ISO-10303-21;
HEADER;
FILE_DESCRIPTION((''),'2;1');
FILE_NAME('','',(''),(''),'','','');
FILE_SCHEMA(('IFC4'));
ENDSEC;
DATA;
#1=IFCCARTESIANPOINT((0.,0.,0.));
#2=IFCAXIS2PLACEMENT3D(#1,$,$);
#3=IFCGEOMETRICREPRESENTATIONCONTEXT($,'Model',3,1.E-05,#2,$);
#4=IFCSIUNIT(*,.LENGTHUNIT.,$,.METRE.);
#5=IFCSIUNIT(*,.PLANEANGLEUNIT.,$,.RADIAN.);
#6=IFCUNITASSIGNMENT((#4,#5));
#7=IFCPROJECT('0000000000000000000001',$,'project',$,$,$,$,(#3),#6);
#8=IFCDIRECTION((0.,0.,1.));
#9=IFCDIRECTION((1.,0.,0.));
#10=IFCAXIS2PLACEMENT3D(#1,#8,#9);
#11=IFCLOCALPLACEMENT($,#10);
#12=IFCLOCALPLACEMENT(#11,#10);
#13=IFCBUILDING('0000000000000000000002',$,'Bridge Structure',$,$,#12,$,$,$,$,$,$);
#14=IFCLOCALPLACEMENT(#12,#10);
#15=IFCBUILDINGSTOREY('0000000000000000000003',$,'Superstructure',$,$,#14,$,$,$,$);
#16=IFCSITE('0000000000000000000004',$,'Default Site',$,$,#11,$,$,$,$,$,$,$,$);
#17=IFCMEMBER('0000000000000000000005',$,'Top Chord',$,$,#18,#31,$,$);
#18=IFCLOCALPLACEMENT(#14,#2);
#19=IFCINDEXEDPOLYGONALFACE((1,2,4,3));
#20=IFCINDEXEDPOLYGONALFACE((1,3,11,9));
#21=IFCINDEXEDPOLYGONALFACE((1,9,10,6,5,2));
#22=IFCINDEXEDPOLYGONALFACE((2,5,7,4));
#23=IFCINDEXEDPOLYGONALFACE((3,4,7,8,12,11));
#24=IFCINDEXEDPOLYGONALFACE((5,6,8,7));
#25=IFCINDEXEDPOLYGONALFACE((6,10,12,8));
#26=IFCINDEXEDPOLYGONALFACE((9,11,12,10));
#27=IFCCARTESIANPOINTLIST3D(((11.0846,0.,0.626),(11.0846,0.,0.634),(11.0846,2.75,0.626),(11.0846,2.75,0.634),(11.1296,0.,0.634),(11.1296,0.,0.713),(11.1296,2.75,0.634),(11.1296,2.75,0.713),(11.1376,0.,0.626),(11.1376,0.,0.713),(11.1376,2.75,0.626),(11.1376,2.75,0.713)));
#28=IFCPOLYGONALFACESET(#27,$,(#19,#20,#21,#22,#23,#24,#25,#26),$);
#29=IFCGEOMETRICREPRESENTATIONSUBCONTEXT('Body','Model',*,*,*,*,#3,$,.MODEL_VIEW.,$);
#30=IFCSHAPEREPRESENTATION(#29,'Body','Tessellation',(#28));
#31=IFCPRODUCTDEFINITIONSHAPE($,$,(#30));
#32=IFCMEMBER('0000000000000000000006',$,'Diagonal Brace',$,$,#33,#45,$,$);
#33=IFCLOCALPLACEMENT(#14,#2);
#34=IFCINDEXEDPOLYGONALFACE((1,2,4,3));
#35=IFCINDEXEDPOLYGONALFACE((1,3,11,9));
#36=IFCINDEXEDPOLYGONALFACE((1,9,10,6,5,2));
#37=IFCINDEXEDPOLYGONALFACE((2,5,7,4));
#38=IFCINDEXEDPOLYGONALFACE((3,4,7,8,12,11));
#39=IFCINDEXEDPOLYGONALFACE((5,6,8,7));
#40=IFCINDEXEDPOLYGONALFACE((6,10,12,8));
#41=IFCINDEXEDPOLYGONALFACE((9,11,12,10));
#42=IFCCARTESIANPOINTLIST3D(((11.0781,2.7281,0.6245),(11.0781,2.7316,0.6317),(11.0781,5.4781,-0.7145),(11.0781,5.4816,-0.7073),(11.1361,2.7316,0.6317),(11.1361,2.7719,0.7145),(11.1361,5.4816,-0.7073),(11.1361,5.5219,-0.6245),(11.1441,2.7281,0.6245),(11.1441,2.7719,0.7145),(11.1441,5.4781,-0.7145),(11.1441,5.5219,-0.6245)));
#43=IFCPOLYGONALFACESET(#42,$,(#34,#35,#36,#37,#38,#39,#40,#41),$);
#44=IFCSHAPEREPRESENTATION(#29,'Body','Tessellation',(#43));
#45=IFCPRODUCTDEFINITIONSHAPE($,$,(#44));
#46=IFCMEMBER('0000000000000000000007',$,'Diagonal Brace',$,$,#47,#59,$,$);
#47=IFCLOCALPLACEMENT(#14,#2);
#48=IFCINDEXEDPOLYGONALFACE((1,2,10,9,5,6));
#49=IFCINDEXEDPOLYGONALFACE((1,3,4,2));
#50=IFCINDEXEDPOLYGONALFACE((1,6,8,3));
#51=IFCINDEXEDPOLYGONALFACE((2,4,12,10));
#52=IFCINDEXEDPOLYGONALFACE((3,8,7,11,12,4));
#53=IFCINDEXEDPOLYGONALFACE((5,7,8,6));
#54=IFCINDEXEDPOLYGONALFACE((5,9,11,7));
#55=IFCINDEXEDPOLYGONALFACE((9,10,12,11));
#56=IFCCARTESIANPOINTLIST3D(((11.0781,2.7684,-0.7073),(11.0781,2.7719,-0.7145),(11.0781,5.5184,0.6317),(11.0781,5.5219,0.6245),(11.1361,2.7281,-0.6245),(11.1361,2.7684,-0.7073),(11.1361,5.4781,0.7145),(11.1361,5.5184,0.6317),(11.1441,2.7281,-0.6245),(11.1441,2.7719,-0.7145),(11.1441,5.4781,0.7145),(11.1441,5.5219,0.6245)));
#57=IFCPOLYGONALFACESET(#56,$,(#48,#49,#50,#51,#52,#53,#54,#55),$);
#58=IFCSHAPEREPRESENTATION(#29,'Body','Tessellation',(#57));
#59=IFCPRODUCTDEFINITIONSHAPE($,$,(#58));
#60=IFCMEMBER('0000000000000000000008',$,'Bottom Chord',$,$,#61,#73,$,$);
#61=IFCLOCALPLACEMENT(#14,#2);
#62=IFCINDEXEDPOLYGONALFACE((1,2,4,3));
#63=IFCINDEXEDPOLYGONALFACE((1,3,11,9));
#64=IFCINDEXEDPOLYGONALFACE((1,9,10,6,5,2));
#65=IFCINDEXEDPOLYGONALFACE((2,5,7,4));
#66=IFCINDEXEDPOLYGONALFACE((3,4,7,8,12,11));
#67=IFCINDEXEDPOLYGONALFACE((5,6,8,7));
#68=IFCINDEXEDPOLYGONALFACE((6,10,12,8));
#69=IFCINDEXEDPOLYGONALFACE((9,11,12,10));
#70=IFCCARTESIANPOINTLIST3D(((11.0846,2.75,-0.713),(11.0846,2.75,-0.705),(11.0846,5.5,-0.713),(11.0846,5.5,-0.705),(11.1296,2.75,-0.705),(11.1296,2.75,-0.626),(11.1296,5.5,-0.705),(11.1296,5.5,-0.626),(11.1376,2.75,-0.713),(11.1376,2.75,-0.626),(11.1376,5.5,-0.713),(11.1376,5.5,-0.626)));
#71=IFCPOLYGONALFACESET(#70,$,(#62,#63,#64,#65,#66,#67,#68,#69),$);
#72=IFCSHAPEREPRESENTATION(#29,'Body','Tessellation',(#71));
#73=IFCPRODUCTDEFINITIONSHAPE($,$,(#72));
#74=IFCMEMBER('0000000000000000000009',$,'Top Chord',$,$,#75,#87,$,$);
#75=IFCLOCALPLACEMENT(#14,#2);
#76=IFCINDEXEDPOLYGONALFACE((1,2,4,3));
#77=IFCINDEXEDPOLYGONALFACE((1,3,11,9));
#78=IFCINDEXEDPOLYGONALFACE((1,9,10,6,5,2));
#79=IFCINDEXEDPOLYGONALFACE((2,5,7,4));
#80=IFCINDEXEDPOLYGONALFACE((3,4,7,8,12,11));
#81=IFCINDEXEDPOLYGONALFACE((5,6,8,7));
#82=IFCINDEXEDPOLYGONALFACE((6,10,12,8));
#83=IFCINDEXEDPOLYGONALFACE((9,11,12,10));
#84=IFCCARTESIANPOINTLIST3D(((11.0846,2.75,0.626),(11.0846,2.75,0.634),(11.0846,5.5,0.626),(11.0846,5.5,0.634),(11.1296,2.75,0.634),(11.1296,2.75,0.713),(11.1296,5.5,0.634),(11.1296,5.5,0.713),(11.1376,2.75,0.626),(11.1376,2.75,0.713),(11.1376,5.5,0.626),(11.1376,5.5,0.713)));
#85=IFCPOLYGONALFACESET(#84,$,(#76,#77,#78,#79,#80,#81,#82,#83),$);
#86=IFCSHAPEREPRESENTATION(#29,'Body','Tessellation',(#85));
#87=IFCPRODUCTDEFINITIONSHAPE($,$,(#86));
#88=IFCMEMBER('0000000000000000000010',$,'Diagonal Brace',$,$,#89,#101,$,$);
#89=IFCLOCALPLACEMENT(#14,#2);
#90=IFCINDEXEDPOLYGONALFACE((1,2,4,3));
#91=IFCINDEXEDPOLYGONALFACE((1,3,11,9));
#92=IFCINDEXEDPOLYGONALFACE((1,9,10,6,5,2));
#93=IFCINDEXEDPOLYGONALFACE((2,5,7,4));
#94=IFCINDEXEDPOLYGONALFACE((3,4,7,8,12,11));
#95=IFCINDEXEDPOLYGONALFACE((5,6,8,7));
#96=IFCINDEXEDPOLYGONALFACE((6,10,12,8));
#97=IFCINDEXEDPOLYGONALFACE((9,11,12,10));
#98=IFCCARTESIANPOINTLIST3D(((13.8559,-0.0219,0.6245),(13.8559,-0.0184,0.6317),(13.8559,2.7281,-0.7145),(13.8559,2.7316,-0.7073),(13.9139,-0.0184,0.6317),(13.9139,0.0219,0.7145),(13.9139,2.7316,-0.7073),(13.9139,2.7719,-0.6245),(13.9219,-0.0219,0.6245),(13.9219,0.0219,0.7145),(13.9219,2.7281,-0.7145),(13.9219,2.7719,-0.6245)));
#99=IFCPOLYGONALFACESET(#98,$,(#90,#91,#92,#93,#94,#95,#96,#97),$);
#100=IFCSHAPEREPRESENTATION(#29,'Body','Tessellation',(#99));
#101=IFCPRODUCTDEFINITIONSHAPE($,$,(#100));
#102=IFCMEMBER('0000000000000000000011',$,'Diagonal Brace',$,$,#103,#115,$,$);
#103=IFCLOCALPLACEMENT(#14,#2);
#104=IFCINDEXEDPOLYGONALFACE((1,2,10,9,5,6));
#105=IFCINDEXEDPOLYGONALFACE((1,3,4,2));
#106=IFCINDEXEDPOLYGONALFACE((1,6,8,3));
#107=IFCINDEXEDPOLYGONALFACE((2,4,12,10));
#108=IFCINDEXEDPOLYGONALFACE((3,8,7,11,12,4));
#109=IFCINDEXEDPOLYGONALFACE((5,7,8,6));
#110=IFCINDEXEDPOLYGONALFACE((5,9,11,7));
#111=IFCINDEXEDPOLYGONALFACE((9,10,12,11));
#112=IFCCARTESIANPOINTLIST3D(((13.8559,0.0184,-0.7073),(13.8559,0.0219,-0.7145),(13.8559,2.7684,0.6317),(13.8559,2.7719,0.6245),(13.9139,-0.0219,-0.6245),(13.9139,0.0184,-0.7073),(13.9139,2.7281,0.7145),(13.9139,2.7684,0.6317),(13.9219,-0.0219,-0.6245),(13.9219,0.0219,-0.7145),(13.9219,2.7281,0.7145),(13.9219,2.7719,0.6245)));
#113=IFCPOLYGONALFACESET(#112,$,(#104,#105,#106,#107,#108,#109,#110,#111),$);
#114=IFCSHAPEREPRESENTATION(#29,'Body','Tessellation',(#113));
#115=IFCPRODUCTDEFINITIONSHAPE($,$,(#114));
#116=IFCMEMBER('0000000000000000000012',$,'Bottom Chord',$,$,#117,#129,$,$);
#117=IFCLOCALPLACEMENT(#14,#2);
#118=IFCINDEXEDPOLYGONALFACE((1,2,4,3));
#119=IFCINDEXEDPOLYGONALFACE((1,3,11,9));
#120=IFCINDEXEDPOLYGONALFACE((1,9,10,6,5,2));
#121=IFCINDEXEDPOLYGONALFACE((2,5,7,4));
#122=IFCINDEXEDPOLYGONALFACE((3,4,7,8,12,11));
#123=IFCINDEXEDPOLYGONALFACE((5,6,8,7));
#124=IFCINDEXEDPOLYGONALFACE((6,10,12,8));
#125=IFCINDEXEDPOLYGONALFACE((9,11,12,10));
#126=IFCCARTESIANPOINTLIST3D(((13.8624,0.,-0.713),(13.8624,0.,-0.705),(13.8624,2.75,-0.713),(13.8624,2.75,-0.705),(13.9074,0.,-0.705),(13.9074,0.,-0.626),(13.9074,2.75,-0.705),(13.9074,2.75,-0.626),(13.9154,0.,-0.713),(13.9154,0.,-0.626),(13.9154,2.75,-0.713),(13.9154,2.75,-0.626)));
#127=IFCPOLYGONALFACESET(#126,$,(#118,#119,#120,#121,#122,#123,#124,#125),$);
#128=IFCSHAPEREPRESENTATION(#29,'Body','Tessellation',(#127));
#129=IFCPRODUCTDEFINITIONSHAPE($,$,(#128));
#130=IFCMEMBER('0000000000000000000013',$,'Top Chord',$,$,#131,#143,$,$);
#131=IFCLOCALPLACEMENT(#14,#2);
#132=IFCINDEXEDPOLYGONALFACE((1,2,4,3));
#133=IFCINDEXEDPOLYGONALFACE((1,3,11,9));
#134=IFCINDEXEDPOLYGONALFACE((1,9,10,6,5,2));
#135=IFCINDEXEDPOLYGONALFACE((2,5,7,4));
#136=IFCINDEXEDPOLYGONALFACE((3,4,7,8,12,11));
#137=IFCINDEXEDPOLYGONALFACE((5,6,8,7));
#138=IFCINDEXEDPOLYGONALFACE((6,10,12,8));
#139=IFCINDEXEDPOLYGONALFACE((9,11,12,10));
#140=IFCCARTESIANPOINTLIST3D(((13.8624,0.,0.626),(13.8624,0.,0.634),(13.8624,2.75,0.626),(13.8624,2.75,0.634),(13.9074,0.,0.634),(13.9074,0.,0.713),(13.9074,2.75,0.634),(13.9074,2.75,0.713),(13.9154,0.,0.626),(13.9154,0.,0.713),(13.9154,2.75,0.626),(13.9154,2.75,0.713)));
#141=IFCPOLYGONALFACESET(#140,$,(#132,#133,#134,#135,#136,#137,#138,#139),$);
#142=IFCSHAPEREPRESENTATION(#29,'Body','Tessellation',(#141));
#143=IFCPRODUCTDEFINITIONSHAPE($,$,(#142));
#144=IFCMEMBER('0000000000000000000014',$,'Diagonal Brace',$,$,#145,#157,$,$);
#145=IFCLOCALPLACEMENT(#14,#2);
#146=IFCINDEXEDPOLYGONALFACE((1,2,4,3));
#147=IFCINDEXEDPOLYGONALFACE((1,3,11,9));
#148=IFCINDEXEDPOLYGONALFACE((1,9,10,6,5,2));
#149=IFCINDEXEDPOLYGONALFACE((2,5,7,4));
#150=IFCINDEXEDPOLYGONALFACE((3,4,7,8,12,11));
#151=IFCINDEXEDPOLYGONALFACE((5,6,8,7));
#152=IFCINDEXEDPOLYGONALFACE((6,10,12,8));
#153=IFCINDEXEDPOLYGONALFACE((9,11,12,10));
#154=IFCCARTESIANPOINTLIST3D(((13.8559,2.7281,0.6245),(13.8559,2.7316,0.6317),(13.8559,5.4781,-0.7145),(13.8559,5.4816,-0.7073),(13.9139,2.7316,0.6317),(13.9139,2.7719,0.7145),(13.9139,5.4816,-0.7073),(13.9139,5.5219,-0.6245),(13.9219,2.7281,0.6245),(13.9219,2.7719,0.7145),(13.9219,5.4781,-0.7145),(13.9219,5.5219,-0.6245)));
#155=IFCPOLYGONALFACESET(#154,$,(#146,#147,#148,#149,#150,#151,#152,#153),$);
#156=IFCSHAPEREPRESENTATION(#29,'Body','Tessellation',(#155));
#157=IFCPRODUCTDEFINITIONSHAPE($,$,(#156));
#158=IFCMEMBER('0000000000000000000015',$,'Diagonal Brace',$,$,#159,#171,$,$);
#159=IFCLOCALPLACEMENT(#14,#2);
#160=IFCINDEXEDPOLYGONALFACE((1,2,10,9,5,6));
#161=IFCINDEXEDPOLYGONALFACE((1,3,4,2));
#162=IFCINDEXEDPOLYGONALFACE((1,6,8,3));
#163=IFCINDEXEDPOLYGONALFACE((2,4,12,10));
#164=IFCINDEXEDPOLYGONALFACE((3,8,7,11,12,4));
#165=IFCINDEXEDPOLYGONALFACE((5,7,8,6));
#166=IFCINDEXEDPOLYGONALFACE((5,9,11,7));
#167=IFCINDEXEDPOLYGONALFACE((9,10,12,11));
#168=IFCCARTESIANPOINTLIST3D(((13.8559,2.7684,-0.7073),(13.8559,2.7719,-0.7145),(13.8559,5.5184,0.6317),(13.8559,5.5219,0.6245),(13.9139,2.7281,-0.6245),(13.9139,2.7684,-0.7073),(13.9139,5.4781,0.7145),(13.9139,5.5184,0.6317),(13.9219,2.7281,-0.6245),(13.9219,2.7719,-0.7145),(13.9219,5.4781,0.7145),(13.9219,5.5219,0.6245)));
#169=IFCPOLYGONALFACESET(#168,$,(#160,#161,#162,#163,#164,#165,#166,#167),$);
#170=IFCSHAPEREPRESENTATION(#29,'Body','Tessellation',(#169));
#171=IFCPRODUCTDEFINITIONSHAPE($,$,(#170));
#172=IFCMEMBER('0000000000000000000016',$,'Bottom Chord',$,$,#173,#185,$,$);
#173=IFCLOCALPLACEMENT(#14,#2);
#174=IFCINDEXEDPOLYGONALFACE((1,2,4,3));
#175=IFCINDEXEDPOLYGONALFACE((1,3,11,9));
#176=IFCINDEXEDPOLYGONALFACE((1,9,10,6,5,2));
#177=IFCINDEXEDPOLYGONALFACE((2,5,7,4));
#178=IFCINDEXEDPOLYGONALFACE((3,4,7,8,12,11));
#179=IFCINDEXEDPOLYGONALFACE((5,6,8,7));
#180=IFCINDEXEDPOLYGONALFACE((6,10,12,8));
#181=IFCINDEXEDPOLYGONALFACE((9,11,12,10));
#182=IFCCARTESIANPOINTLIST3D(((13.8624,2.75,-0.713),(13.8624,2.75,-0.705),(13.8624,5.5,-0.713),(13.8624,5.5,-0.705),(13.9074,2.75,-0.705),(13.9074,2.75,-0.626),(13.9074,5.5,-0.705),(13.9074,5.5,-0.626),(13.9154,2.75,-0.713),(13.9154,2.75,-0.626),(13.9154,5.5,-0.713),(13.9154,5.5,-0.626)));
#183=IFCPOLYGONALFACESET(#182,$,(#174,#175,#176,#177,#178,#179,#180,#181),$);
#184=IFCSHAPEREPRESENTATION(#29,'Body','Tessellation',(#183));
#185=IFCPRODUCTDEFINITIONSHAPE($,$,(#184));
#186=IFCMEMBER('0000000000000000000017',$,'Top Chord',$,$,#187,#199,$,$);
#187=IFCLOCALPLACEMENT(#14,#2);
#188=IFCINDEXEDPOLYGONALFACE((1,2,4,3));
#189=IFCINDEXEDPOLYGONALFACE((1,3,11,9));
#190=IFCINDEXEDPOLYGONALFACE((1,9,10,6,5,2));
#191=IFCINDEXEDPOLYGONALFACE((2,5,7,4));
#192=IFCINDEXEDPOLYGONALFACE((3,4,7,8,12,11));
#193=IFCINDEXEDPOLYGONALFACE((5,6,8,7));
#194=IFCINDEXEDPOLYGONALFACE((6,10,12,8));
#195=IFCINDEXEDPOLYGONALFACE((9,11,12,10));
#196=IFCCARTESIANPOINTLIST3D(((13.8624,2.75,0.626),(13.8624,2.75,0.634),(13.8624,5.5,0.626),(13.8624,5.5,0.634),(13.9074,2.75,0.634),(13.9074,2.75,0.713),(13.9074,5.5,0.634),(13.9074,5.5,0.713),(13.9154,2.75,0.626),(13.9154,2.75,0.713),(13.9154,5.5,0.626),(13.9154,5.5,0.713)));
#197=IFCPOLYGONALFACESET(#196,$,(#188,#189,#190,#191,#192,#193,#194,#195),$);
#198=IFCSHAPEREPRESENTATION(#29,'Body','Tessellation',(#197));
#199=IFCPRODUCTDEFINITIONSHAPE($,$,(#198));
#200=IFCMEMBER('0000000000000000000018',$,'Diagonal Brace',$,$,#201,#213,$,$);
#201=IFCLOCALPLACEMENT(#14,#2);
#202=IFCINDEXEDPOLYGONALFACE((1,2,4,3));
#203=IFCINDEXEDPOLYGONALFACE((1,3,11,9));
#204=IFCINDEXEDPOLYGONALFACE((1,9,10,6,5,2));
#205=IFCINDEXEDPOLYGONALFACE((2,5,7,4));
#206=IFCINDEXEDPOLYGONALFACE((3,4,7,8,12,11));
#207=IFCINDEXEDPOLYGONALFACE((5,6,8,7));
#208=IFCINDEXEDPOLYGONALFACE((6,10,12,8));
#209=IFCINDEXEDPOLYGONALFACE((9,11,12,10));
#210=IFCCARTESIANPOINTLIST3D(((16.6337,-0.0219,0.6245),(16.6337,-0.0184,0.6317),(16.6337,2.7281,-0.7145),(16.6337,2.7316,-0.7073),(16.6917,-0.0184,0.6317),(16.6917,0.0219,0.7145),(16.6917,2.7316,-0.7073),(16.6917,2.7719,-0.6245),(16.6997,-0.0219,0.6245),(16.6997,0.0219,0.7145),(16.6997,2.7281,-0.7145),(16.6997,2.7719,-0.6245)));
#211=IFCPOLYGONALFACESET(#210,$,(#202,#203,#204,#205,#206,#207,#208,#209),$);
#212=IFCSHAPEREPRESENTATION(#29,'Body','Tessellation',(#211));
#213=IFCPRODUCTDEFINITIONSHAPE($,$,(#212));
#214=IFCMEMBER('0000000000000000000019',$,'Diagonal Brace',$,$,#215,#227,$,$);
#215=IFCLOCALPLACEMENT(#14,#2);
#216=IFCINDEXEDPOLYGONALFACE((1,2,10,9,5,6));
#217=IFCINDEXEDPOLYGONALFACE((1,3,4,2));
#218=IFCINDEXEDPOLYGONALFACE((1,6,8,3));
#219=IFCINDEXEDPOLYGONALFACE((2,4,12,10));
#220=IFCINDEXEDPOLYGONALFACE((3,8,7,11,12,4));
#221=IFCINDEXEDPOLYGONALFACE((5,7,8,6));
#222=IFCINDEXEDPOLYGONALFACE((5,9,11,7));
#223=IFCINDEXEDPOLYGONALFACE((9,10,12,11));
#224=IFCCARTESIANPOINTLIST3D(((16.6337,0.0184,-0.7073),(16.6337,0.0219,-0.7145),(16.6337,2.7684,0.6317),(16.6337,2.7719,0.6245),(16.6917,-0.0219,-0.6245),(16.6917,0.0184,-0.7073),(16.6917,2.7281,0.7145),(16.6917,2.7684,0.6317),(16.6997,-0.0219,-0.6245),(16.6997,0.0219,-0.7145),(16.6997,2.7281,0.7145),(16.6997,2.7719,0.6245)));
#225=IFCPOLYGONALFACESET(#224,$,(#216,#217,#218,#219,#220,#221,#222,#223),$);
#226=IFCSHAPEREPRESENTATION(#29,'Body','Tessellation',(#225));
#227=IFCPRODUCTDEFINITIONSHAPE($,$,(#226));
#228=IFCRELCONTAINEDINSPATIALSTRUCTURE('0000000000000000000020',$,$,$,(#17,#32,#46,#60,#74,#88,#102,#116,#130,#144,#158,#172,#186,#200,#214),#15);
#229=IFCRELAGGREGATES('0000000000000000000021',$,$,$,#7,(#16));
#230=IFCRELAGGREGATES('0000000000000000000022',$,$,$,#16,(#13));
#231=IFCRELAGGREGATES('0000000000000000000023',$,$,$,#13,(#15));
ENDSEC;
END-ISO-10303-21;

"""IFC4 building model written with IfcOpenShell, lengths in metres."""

from ifc_helpers import new_model, si_unit, frame, origin, origin_with_axes, origin_2d_with_axis, place, context, subcontext, project, spatial, l_section, extrude, element, save


model = new_model("IFC4")

# Units and contexts
model_context = context("Model", 3, precision=1e-05, world=origin())
body_context = subcontext(model_context, "Body", "Model", "MODEL_VIEW")
ifc_project = project(units=[si_unit("LENGTHUNIT", "METRE"), si_unit("PLANEANGLEUNIT", "RADIAN")], contexts=[model_context])

# Site, building, storey
site_placement = place(None, origin_with_axes())
site = spatial("IfcSite", under=ifc_project, at=site_placement, Name="Default Site")
building_placement = place(site_placement, origin_with_axes())
building = spatial("IfcBuilding", under=site, at=building_placement, Name="Bridge Structure")
storey_placement = place(building_placement, origin_with_axes())
storey = spatial("IfcBuildingStorey", under=building, at=storey_placement, Name="Superstructure")

# Members
member_placement = place(storey_placement, frame((11.1111, 0.0, 0.6695), z_axis=(0.0, 1.0, 0.0), x_axis=(-1.0, 0.0, 0.0)))
element("IfcMember", 1, at=member_placement, inside=storey, Name="Top Chord", context=body_context, shape_type="SweptSolid", body=[
    extrude(l_section(Depth=0.087, Width=0.053, Thickness=0.008, at=origin_2d_with_axis()), origin_with_axes(), (0.0, 0.0, 1.0), 2.75),
])
for number, where, z_axis, x_axis, name in (
    (2, (11.1111, 2.75, 0.6695), (0.0, 0.899086, -0.437773), (-1.0, 0.0, 0.0), "Diagonal Brace"),
    (3, (11.1111, 2.75, -0.6695), (0.0, 0.899086, 0.437773), (-1.0, 0.0, 0.0), "Diagonal Brace"),
):
    element("IfcMember", number, at=place(storey_placement, frame(where, z_axis=z_axis, x_axis=x_axis)), inside=storey, Name=name, context=body_context, shape_type="SweptSolid", body=[
        extrude(l_section(Depth=0.1, Width=0.066, Thickness=0.008, at=origin_2d_with_axis()), origin_with_axes(), (0.0, 0.0, 1.0), 3.0587),
    ])
for number, where, z_axis, x_axis, name in (
    (4, (11.1111, 2.75, -0.6695), (0.0, 1.0, 0.0), (-1.0, 0.0, 0.0), "Bottom Chord"),
    (5, (11.1111, 2.75, 0.6695), (0.0, 1.0, 0.0), (-1.0, 0.0, 0.0), "Top Chord"),
):
    element("IfcMember", number, at=place(storey_placement, frame(where, z_axis=z_axis, x_axis=x_axis)), inside=storey, Name=name, context=body_context, shape_type="SweptSolid", body=[
        extrude(l_section(Depth=0.087, Width=0.053, Thickness=0.008, at=origin_2d_with_axis()), origin_with_axes(), (0.0, 0.0, 1.0), 2.75),
    ])
for number, where, z_axis, x_axis, name in (
    (6, (13.8889, 0.0, 0.6695), (0.0, 0.899086, -0.437773), (-1.0, 0.0, 0.0), "Diagonal Brace"),
    (7, (13.8889, 0.0, -0.6695), (0.0, 0.899086, 0.437773), (-1.0, 0.0, 0.0), "Diagonal Brace"),
):
    element("IfcMember", number, at=place(storey_placement, frame(where, z_axis=z_axis, x_axis=x_axis)), inside=storey, Name=name, context=body_context, shape_type="SweptSolid", body=[
        extrude(l_section(Depth=0.1, Width=0.066, Thickness=0.008, at=origin_2d_with_axis()), origin_with_axes(), (0.0, 0.0, 1.0), 3.0587),
    ])
for number, where, z_axis, x_axis, name in (
    (8, (13.8889, 0.0, -0.6695), (0.0, 1.0, 0.0), (-1.0, 0.0, 0.0), "Bottom Chord"),
    (9, (13.8889, 0.0, 0.6695), (0.0, 1.0, 0.0), (-1.0, 0.0, 0.0), "Top Chord"),
):
    element("IfcMember", number, at=place(storey_placement, frame(where, z_axis=z_axis, x_axis=x_axis)), inside=storey, Name=name, context=body_context, shape_type="SweptSolid", body=[
        extrude(l_section(Depth=0.087, Width=0.053, Thickness=0.008, at=origin_2d_with_axis()), origin_with_axes(), (0.0, 0.0, 1.0), 2.75),
    ])
for number, where, z_axis, x_axis, name in (
    (10, (13.8889, 2.75, 0.6695), (0.0, 0.899086, -0.437773), (-1.0, 0.0, 0.0), "Diagonal Brace"),
    (11, (13.8889, 2.75, -0.6695), (0.0, 0.899086, 0.437773), (-1.0, 0.0, 0.0), "Diagonal Brace"),
):
    element("IfcMember", number, at=place(storey_placement, frame(where, z_axis=z_axis, x_axis=x_axis)), inside=storey, Name=name, context=body_context, shape_type="SweptSolid", body=[
        extrude(l_section(Depth=0.1, Width=0.066, Thickness=0.008, at=origin_2d_with_axis()), origin_with_axes(), (0.0, 0.0, 1.0), 3.0587),
    ])
for number, where, z_axis, x_axis, name in (
    (12, (13.8889, 2.75, -0.6695), (0.0, 1.0, 0.0), (-1.0, 0.0, 0.0), "Bottom Chord"),
    (13, (13.8889, 2.75, 0.6695), (0.0, 1.0, 0.0), (-1.0, 0.0, 0.0), "Top Chord"),
):
    element("IfcMember", number, at=place(storey_placement, frame(where, z_axis=z_axis, x_axis=x_axis)), inside=storey, Name=name, context=body_context, shape_type="SweptSolid", body=[
        extrude(l_section(Depth=0.087, Width=0.053, Thickness=0.008, at=origin_2d_with_axis()), origin_with_axes(), (0.0, 0.0, 1.0), 2.75),
    ])
for number, where, z_axis, x_axis, name in (
    (14, (16.6667, 0.0, 0.6695), (0.0, 0.899086, -0.437773), (-1.0, 0.0, 0.0), "Diagonal Brace"),
    (15, (16.6667, 0.0, -0.6695), (0.0, 0.899086, 0.437773), (-1.0, 0.0, 0.0), "Diagonal Brace"),
):
    element("IfcMember", number, at=place(storey_placement, frame(where, z_axis=z_axis, x_axis=x_axis)), inside=storey, Name=name, context=body_context, shape_type="SweptSolid", body=[
        extrude(l_section(Depth=0.1, Width=0.066, Thickness=0.008, at=origin_2d_with_axis()), origin_with_axes(), (0.0, 0.0, 1.0), 3.0587),
    ])

save(model, "model.ifc")
